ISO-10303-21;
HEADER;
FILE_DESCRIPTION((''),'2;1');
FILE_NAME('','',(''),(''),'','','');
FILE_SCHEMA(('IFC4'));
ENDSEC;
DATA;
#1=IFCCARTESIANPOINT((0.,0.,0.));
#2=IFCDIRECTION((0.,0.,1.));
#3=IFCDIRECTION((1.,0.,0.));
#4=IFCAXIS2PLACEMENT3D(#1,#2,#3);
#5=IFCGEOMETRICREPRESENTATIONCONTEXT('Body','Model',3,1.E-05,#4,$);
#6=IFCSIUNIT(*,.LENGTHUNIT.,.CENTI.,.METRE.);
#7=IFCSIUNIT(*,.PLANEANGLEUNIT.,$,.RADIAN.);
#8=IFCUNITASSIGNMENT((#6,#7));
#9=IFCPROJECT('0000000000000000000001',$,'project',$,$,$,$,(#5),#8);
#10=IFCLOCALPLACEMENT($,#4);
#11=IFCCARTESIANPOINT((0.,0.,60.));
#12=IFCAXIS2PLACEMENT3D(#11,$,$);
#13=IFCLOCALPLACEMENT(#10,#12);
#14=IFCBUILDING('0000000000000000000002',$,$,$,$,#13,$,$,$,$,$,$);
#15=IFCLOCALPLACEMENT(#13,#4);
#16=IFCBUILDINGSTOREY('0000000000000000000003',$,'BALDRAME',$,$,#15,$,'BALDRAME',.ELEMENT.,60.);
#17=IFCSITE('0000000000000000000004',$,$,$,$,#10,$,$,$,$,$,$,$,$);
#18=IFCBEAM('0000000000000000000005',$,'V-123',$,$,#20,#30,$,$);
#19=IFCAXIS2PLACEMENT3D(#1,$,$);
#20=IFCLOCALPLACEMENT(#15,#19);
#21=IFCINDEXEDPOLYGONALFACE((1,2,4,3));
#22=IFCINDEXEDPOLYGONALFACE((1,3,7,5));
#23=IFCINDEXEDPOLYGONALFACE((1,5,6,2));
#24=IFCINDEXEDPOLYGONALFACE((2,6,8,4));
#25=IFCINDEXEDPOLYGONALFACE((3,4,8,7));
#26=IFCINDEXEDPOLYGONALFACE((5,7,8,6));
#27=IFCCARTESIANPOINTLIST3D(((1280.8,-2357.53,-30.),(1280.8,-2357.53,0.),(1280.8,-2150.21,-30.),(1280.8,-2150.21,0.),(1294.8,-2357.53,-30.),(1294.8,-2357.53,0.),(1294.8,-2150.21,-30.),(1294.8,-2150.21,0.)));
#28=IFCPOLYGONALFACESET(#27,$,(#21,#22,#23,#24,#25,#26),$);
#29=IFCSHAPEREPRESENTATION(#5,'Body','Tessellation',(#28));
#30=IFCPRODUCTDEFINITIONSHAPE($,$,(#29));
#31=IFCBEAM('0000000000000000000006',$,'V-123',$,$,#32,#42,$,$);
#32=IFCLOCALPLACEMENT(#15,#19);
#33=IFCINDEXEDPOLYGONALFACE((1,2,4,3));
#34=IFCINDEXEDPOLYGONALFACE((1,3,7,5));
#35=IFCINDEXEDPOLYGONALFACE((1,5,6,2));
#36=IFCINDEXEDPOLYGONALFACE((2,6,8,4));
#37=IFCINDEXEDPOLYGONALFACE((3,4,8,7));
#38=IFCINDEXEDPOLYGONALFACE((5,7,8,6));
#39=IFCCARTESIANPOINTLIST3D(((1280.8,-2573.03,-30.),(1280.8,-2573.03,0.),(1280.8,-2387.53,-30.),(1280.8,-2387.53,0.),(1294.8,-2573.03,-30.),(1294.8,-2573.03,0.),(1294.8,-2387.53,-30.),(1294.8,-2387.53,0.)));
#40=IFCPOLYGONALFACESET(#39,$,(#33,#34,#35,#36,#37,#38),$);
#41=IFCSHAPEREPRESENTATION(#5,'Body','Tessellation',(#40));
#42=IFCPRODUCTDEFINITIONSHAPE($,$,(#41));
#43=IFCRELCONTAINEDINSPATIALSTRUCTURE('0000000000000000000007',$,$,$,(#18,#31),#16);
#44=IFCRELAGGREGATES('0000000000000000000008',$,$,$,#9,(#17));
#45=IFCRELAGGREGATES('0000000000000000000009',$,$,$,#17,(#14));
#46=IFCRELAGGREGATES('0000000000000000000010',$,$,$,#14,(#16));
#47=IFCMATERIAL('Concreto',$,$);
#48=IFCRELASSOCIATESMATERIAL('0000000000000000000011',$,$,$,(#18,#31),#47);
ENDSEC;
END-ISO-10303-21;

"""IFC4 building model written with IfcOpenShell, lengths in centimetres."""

from ifc_helpers import new_model, si_unit, frame, origin_with_axes, origin_2d_with_axis, place, context, project, spatial, rectangle, extrude, material, element, save


model = new_model("IFC4")

# Units and contexts
model_context = context("Model", 3, precision=1e-05, world=origin_with_axes(), identifier="Body")
ifc_project = project(units=[si_unit("LENGTHUNIT", "METRE", prefix="CENTI"), si_unit("PLANEANGLEUNIT", "RADIAN")], contexts=[model_context])

# Site, building, storey
site_placement = place(None, origin_with_axes())
site = spatial("IfcSite", under=ifc_project, at=site_placement)
building_placement = place(site_placement, frame((0.0, 0.0, 60.0)))
building = spatial("IfcBuilding", under=site, at=building_placement)
storey_placement = place(building_placement, origin_with_axes())
storey = spatial("IfcBuildingStorey", under=building, at=storey_placement, Name="BALDRAME", LongName="BALDRAME", CompositionType="ELEMENT", Elevation=60.0)

# Shared definitions
ifc_material = material(Name="Concreto")

# Beams
beam_1_placement = place(storey_placement, frame((1287.8, -2253.87, 0.0), z_axis=(0.0, 0.0, 1.0), x_axis=(1.0, 0.0, 0.0)))
element("IfcBeam", 1, at=beam_1_placement, inside=storey, material=ifc_material, Name="V-123", context=model_context, shape_type="SolidModel", body=[
    extrude(rectangle(XDim=14.0, YDim=30.0, at=origin_2d_with_axis()), frame((0.0, -103.66, -15.0), z_axis=(0.0, 1.0, 0.0), x_axis=(1.0, 0.0, 0.0)), (0.0, 0.0, 1.0), 207.32),
])
beam_2_placement = place(storey_placement, frame((1287.8, -2480.28, 0.0), z_axis=(0.0, 0.0, 1.0), x_axis=(1.0, 0.0, 0.0)))
element("IfcBeam", 2, at=beam_2_placement, inside=storey, material=ifc_material, Name="V-123", context=model_context, shape_type="SolidModel", body=[
    extrude(rectangle(XDim=14.0, YDim=30.0, at=origin_2d_with_axis()), frame((0.0, -92.75, -15.0), z_axis=(0.0, 1.0, 0.0), x_axis=(1.0, 0.0, 0.0)), (0.0, 0.0, 1.0), 185.5),
])

save(model, "model.ifc")
